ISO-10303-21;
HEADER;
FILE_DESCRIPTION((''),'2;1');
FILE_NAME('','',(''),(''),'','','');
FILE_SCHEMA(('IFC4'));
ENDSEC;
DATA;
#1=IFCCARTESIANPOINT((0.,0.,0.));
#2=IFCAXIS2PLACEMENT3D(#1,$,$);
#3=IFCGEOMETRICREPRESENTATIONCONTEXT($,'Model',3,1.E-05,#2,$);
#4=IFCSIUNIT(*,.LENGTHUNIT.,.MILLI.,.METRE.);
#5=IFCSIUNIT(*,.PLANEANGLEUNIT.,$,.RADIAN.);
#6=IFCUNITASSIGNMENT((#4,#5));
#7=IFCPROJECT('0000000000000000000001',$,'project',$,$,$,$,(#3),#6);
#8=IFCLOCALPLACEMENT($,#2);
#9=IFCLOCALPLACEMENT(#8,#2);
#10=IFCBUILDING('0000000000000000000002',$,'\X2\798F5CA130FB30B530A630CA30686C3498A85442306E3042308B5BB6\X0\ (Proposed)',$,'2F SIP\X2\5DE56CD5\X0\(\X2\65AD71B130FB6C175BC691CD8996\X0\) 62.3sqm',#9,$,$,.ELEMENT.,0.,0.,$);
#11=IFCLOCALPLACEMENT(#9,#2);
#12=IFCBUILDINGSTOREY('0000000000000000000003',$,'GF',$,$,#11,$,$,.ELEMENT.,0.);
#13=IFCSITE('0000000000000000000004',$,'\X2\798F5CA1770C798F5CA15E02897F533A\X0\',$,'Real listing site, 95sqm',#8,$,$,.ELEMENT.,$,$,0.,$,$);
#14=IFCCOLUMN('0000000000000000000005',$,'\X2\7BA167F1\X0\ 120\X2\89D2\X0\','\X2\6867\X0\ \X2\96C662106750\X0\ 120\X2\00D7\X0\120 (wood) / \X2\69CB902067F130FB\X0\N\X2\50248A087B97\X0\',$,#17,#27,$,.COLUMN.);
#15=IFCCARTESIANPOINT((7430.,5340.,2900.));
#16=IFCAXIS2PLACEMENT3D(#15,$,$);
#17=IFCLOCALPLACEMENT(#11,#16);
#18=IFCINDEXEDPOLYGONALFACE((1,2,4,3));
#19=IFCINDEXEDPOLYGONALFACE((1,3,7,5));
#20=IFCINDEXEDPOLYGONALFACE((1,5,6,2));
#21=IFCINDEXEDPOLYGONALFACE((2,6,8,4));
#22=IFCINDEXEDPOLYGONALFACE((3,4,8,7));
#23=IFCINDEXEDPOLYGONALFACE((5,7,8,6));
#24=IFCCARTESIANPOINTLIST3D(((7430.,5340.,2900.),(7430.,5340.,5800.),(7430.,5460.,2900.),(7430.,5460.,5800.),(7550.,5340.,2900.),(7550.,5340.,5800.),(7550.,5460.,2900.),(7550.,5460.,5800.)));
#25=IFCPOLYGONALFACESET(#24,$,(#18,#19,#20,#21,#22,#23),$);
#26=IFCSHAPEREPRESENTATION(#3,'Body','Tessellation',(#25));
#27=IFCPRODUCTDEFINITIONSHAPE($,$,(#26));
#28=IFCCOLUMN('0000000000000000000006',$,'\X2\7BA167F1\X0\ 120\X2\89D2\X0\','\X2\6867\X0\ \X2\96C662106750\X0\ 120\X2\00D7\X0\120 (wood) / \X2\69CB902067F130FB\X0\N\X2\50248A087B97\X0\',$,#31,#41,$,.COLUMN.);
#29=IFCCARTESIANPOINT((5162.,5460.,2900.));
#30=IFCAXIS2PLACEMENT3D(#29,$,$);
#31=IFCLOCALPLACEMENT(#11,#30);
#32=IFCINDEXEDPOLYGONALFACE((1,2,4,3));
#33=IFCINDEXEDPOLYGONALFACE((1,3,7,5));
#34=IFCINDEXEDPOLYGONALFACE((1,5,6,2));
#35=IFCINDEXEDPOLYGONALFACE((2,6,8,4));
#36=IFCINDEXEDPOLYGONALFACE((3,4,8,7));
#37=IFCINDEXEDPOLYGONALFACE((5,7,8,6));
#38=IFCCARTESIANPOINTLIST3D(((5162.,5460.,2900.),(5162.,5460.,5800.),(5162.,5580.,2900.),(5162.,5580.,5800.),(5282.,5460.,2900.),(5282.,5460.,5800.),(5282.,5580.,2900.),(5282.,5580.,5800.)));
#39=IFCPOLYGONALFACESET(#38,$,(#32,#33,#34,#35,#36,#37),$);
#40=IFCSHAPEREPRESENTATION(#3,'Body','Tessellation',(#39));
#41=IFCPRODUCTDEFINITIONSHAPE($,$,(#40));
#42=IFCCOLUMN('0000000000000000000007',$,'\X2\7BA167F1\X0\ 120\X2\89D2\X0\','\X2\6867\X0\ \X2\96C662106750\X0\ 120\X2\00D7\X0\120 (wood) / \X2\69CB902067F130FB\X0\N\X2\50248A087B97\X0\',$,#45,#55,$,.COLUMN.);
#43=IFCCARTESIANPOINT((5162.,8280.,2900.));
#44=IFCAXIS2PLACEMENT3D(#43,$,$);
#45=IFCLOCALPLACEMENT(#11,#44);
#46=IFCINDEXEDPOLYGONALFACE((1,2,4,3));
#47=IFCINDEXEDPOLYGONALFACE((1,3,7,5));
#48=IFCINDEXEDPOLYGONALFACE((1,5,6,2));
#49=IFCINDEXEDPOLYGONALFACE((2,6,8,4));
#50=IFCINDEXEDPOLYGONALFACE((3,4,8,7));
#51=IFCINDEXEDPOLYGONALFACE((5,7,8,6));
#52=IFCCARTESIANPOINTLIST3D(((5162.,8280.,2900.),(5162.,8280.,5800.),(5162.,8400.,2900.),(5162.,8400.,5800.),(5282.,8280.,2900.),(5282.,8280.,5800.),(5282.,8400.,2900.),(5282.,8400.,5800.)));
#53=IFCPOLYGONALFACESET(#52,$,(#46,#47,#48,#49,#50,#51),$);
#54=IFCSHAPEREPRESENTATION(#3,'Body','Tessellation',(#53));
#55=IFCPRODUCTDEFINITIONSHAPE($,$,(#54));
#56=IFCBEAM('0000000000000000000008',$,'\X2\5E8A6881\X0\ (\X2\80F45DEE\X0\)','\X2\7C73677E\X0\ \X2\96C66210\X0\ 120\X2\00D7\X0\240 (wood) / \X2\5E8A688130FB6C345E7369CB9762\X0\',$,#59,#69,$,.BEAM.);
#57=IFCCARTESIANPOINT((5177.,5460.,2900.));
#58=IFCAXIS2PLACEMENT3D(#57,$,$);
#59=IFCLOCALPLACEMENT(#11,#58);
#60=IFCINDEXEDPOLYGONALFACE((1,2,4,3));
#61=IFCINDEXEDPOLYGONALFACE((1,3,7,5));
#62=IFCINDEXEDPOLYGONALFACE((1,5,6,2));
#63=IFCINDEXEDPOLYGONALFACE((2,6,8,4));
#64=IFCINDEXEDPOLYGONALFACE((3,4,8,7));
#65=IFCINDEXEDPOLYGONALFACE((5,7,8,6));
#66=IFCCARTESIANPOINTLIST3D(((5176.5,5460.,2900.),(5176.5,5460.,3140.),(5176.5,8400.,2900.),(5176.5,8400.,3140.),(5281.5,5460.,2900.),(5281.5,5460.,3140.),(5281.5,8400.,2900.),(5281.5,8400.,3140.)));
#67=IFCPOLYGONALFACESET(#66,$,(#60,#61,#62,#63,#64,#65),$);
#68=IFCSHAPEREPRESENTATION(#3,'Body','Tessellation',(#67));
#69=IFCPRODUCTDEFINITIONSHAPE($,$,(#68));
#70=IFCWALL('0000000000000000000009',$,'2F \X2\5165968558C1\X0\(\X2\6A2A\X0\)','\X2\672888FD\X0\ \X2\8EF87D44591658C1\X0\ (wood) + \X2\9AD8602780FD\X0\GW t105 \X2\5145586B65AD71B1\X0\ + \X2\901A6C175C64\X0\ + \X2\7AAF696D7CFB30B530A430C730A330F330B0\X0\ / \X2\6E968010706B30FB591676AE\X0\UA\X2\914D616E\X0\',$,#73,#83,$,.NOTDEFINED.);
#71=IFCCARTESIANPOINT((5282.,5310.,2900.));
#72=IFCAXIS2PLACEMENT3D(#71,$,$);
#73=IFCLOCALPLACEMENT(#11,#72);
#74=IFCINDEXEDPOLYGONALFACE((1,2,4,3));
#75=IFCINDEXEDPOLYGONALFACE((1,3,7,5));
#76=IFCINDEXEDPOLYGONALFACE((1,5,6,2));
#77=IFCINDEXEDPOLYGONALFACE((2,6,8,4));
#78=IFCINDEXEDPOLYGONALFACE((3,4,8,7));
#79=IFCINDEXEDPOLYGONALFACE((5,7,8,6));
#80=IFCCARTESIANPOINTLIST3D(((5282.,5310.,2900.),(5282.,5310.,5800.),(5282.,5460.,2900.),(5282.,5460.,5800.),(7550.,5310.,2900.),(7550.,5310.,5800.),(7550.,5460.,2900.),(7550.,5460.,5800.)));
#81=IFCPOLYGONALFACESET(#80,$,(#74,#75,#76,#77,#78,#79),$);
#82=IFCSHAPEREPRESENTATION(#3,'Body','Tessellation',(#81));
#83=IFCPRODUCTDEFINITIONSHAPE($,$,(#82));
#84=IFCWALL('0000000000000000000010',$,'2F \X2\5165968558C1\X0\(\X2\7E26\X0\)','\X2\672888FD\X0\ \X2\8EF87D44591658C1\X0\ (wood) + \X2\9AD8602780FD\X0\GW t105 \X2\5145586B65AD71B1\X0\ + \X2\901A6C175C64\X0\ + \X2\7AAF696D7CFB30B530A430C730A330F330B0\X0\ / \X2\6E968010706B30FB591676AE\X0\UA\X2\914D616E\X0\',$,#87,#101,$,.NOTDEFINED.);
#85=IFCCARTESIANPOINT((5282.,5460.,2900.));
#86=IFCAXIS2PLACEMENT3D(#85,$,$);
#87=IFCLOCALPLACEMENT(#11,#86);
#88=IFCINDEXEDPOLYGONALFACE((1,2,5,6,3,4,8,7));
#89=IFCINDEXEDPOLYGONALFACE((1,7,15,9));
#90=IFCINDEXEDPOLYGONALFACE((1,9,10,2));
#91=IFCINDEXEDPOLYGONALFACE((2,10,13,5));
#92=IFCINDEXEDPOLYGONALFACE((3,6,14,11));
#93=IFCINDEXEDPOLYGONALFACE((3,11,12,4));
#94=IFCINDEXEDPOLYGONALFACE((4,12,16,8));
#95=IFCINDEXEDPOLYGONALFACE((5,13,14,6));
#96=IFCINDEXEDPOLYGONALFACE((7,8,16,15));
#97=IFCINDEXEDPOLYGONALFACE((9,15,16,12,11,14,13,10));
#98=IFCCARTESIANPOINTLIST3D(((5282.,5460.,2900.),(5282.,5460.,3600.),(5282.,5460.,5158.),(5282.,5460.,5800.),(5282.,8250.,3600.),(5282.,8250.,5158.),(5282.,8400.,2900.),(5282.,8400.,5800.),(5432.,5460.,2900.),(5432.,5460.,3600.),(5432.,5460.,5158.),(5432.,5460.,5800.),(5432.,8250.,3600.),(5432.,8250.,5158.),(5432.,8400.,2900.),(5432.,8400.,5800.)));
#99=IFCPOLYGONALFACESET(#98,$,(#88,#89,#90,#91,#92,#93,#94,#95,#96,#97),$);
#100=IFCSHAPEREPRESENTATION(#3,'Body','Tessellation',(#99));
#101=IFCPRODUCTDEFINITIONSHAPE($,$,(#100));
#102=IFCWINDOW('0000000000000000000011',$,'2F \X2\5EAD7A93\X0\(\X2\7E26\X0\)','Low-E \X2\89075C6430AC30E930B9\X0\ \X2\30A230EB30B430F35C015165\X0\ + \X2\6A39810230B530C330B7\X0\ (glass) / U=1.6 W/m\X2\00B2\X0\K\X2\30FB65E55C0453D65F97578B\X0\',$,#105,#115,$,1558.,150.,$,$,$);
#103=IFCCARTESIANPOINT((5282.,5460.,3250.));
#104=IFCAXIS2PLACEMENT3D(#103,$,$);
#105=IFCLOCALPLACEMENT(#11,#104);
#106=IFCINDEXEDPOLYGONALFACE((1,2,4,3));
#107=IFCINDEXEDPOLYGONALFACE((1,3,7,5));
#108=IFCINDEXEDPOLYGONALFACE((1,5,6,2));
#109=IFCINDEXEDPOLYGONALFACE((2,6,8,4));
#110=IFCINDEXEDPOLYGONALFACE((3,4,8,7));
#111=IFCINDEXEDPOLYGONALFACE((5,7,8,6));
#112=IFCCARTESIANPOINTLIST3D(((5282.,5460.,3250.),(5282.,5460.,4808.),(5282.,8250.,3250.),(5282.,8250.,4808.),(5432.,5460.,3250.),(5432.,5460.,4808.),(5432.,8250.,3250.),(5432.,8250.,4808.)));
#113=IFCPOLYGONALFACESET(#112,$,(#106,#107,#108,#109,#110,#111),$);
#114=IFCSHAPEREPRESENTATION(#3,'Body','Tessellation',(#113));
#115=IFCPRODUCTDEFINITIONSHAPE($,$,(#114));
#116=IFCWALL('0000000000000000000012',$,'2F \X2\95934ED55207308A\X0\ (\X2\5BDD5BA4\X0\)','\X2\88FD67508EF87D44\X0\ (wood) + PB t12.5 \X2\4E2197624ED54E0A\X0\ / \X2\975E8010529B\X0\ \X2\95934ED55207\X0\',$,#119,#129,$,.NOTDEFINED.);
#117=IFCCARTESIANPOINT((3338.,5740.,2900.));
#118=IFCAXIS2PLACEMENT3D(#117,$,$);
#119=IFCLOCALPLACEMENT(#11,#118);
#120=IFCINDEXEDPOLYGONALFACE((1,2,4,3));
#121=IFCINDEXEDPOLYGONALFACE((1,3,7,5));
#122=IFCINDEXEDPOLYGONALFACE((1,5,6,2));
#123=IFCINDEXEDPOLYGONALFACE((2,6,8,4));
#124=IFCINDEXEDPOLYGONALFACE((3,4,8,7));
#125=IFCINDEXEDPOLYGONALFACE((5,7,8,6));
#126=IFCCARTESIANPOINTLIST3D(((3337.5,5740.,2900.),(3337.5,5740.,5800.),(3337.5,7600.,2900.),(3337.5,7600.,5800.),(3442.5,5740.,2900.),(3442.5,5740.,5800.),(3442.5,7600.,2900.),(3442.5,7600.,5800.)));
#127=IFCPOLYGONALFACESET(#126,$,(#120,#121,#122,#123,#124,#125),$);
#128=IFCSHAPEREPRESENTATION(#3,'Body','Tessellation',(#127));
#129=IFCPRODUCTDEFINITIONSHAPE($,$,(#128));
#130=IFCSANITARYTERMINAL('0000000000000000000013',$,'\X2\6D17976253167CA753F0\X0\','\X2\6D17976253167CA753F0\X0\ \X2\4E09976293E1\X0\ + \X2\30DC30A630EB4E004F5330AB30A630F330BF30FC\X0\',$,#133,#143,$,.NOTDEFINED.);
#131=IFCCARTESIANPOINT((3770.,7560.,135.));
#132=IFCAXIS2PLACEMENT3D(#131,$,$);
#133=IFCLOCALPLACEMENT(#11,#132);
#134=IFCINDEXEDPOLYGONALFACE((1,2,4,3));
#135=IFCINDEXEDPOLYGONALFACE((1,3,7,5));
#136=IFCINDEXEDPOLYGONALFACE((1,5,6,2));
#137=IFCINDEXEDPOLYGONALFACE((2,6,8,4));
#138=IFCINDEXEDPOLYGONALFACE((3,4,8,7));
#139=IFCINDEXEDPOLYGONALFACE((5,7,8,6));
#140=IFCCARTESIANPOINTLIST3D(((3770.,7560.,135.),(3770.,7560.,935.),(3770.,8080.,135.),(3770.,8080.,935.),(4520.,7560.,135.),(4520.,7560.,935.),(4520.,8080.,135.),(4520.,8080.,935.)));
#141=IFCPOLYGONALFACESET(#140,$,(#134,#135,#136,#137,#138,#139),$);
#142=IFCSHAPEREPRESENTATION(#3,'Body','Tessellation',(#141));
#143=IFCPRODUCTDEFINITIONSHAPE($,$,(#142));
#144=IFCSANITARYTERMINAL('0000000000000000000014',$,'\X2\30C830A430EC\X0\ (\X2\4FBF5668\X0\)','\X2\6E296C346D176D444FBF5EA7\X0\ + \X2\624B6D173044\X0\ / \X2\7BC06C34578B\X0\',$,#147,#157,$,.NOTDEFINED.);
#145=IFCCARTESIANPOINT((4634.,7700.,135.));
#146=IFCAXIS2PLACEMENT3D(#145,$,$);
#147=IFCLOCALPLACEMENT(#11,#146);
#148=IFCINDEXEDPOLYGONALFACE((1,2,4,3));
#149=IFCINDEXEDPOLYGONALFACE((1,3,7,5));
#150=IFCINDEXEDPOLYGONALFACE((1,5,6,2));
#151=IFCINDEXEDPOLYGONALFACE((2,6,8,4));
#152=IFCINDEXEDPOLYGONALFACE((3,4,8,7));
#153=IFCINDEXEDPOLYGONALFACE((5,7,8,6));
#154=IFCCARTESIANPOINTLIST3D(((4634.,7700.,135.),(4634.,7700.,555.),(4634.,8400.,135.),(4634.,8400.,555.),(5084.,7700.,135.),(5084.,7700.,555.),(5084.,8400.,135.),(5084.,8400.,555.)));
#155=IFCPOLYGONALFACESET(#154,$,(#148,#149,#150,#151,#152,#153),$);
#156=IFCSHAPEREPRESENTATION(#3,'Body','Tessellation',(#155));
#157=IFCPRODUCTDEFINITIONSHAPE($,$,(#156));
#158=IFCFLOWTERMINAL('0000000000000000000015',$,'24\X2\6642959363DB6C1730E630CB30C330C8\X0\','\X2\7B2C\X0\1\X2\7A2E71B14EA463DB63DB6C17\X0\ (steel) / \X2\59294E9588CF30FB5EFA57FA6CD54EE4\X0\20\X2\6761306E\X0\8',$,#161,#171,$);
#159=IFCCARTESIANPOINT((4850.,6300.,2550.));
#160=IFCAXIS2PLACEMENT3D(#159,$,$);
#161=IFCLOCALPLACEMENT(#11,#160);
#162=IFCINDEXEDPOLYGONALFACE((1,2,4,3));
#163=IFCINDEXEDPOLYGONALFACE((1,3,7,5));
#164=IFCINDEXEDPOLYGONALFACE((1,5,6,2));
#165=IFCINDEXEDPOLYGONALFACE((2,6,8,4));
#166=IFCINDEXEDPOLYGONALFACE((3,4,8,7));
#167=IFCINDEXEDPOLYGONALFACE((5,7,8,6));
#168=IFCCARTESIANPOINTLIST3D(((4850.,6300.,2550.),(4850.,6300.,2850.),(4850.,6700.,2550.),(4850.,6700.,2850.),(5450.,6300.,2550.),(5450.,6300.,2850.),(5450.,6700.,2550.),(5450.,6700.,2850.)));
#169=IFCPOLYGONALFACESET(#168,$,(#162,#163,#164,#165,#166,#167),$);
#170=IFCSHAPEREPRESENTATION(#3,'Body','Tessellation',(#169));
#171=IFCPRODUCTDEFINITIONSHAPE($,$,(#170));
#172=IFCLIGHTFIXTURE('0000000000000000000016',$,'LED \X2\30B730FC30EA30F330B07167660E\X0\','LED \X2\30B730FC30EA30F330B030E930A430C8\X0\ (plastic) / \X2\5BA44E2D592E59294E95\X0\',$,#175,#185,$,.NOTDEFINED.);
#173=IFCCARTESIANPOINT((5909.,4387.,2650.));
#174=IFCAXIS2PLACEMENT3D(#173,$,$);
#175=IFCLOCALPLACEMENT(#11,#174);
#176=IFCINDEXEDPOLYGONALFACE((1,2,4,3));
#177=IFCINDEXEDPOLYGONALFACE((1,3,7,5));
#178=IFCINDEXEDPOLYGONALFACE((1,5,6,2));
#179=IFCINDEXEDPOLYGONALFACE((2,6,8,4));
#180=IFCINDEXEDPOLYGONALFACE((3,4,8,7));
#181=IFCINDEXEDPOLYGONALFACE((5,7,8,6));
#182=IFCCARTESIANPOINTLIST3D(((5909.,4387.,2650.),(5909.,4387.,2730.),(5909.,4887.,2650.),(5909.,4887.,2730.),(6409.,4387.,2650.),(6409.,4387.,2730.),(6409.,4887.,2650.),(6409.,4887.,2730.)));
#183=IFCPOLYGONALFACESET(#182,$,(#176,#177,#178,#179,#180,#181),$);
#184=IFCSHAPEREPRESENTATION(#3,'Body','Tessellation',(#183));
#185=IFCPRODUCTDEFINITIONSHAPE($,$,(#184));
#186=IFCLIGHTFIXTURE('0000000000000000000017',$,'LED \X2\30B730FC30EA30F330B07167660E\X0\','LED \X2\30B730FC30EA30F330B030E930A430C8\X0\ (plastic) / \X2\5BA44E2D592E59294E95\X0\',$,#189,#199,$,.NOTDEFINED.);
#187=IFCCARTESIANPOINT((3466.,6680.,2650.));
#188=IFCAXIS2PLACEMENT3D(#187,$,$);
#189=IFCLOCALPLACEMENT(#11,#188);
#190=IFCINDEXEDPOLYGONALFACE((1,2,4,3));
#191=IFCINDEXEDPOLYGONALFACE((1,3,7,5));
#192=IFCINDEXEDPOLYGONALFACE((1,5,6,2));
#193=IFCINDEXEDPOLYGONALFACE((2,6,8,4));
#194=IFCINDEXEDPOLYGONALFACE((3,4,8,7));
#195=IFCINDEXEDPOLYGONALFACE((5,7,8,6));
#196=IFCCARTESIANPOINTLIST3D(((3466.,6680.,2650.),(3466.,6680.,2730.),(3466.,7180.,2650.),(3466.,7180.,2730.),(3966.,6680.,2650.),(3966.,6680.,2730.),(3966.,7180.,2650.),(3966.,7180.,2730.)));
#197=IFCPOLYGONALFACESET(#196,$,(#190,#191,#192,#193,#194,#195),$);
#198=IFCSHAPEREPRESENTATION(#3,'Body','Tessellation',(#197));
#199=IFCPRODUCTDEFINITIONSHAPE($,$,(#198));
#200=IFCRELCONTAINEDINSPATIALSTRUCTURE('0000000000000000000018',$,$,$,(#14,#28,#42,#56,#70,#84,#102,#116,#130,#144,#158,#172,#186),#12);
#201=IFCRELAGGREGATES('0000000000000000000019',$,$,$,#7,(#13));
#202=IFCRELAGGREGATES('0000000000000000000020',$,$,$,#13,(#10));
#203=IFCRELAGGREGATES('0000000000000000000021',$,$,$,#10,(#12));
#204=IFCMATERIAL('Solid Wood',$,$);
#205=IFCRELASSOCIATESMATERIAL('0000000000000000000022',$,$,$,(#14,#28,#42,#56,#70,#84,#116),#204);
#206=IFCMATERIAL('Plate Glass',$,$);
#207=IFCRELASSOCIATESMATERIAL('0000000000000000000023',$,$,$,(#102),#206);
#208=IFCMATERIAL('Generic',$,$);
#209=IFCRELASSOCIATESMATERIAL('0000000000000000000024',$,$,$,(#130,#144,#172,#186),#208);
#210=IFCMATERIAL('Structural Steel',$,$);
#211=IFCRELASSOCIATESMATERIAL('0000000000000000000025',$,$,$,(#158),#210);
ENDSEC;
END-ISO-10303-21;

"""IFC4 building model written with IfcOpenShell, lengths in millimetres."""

from ifc_helpers import new_model, si_unit, frame, frame_2d, origin, place, context, project, spatial, rectangle, extrude, material, element, fill, save


model = new_model("IFC4")

# Units and contexts
model_context = context("Model", 3, precision=1e-05, world=origin())
ifc_project = project(units=[si_unit("LENGTHUNIT", "METRE", prefix="MILLI"), si_unit("PLANEANGLEUNIT", "RADIAN")], contexts=[model_context])

# Site, building, storey
site_placement = place(None, origin())
site = spatial("IfcSite", under=ifc_project, at=site_placement, Name="福岡県福岡市西区", ObjectType="Real listing site, 95sqm", CompositionType="ELEMENT", RefElevation=0.0)
building_placement = place(site_placement, origin())
building = spatial("IfcBuilding", under=site, at=building_placement, Name="福岡・サウナと水風呂のある家 (Proposed)", ObjectType="2F SIP工法(断熱・気密重視) 62.3sqm", CompositionType="ELEMENT", ElevationOfRefHeight=0.0, ElevationOfTerrain=0.0)
storey_placement = place(building_placement, origin())
storey = spatial("IfcBuildingStorey", under=building, at=storey_placement, Name="GF", CompositionType="ELEMENT", Elevation=0.0)

# Columns
ifc_material_1 = material(Name="Solid Wood")
column_1_placement = place(storey_placement, frame((7430.0, 5340.0, 2900.0)))
element("IfcColumn", 1, at=column_1_placement, inside=storey, material=ifc_material_1, Name="管柱 120角", Description="桧 集成材 120×120 (wood) / 構造柱・N値計算", PredefinedType="COLUMN", context=model_context, shape_type="SweptSolid", body=[
    extrude(rectangle(XDim=120.0, YDim=120.0, at=frame_2d((60.0, 60.0))), frame((7430.0, 5340.0, 2900.0)), (0.0, 0.0, 1.0), 2900.0),
])
column_2_placement = place(storey_placement, frame((5162.0, 5460.0, 2900.0)))
element("IfcColumn", 2, at=column_2_placement, inside=storey, material=ifc_material_1, Name="管柱 120角", Description="桧 集成材 120×120 (wood) / 構造柱・N値計算", PredefinedType="COLUMN", context=model_context, shape_type="SweptSolid", body=[
    extrude(rectangle(XDim=120.0, YDim=120.0, at=frame_2d((60.0, 60.0))), frame((5162.0, 5460.0, 2900.0)), (0.0, 0.0, 1.0), 2900.0),
])
column_3_placement = place(storey_placement, frame((5162.0, 8280.0, 2900.0)))
element("IfcColumn", 3, at=column_3_placement, inside=storey, material=ifc_material_1, Name="管柱 120角", Description="桧 集成材 120×120 (wood) / 構造柱・N値計算", PredefinedType="COLUMN", context=model_context, shape_type="SweptSolid", body=[
    extrude(rectangle(XDim=120.0, YDim=120.0, at=frame_2d((60.0, 60.0))), frame((5162.0, 8280.0, 2900.0)), (0.0, 0.0, 1.0), 2900.0),
])

# Beam
beam_placement = place(storey_placement, frame((5177.0, 5460.0, 2900.0)))
element("IfcBeam", 4, at=beam_placement, inside=storey, material=ifc_material_1, Name="床梁 (胴差)", Description="米松 集成 120×240 (wood) / 床梁・水平構面", PredefinedType="BEAM", context=model_context, shape_type="SweptSolid", body=[
    extrude(rectangle(XDim=105.0, YDim=2940.0, at=frame_2d((52.0, 1470.0))), frame((5177.0, 5460.0, 2900.0)), (0.0, 0.0, 1.0), 240.0),
])

# Wall
wall_1_placement = place(storey_placement, frame((5282.0, 5310.0, 2900.0)))
element("IfcWall", 5, at=wall_1_placement, inside=storey, material=ifc_material_1, Name="2F 入隅壁(横)", Description="木製 軸組外壁 (wood) + 高性能GW t105 充填断熱 + 通気層 + 窯業系サイディング / 準耐火・外皮UA配慮", PredefinedType="NOTDEFINED", context=model_context, shape_type="SweptSolid", body=[
    extrude(rectangle(XDim=2268.0, YDim=150.0, at=frame_2d((1134.0, 75.0))), frame((5282.0, 5310.0, 2900.0)), (0.0, 0.0, 1.0), 2900.0),
])

# Wall, opening, window
wall_2_placement = place(storey_placement, frame((5282.0, 5460.0, 2900.0)))
wall_2 = element("IfcWall", 6, at=wall_2_placement, inside=storey, material=ifc_material_1, Name="2F 入隅壁(縦)", Description="木製 軸組外壁 (wood) + 高性能GW t105 充填断熱 + 通気層 + 窯業系サイディング / 準耐火・外皮UA配慮", PredefinedType="NOTDEFINED", context=model_context, shape_type="SweptSolid", body=[
    extrude(rectangle(XDim=150.0, YDim=2940.0, at=frame_2d((75.0, 1470.0))), frame((5282.0, 5460.0, 2900.0)), (0.0, 0.0, 1.0), 2900.0),
])
opening_placement = place(storey_placement, frame((5282.0, 5460.0, 3250.0)))
opening = element("IfcOpeningElement", 7, at=opening_placement, cuts=wall_2, PredefinedType="NOTDEFINED", context=model_context, shape_type="SweptSolid", body=[
    extrude(rectangle(XDim=150.0, YDim=2790.0, at=frame_2d((75.0, 1395.0))), frame((5282.0, 5460.0, 3250.0)), (0.0, 0.0, 1.0), 1558.0),
])
ifc_material_2 = material(Name="Plate Glass")
window_placement = place(storey_placement, frame((5282.0, 5460.0, 3250.0)))
window = element("IfcWindow", 8, at=window_placement, inside=storey, material=ifc_material_2, Name="2F 庭窓(縦)", Description="Low-E 複層ガラス アルゴン封入 + 樹脂サッシ (glass) / U=1.6 W/m²K・日射取得型", OverallHeight=1558.0, OverallWidth=150.0, context=model_context, shape_type="SweptSolid", body=[
    extrude(rectangle(XDim=150.0, YDim=2790.0, at=frame_2d((75.0, 1395.0))), frame((5282.0, 5460.0, 3250.0)), (0.0, 0.0, 1.0), 1558.0),
])
fill(opening, window)

# Wall
wall_3_placement = place(storey_placement, frame((3338.0, 5740.0, 2900.0)))
element("IfcWall", 9, at=wall_3_placement, inside=storey, material=ifc_material_1, Name="2F 間仕切り (寝室)", Description="製材軸組 (wood) + PB t12.5 両面仕上 / 非耐力 間仕切", PredefinedType="NOTDEFINED", context=model_context, shape_type="SweptSolid", body=[
    extrude(rectangle(XDim=105.0, YDim=1860.0, at=frame_2d((52.0, 930.0))), frame((3338.0, 5740.0, 2900.0)), (0.0, 0.0, 1.0), 2900.0),
])

# Sanitary terminals
ifc_material_3 = material(Name="Generic")
sanitary_terminal_1_placement = place(storey_placement, frame((3770.0, 7560.0, 135.0)))
element("IfcSanitaryTerminal", 10, at=sanitary_terminal_1_placement, inside=storey, material=ifc_material_3, Name="洗面化粧台", Description="洗面化粧台 三面鏡 + ボウル一体カウンター", PredefinedType="NOTDEFINED", context=model_context, shape_type="SweptSolid", body=[
    extrude(rectangle(XDim=750.0, YDim=520.0, at=frame_2d((375.0, 260.0))), frame((3770.0, 7560.0, 135.0)), (0.0, 0.0, 1.0), 800.0),
])
sanitary_terminal_2_placement = place(storey_placement, frame((4634.0, 7700.0, 135.0)))
element("IfcSanitaryTerminal", 11, at=sanitary_terminal_2_placement, inside=storey, material=ifc_material_3, Name="トイレ (便器)", Description="温水洗浄便座 + 手洗い / 節水型", PredefinedType="NOTDEFINED", context=model_context, shape_type="SweptSolid", body=[
    extrude(rectangle(XDim=450.0, YDim=700.0, at=frame_2d((225.0, 350.0))), frame((4634.0, 7700.0, 135.0)), (0.0, 0.0, 1.0), 420.0),
])

# Flow terminal
ifc_material_4 = material(Name="Structural Steel")
flow_terminal_placement = place(storey_placement, frame((4850.0, 6300.0, 2550.0)))
element("IfcFlowTerminal", 12, at=flow_terminal_placement, inside=storey, material=ifc_material_4, Name="24時間換気ユニット", Description="第1種熱交換換気 (steel) / 天井裏・建基法令20条の8", context=model_context, shape_type="SweptSolid", body=[
    extrude(rectangle(XDim=600.0, YDim=400.0, at=frame_2d((300.0, 200.0))), frame((4850.0, 6300.0, 2550.0)), (0.0, 0.0, 1.0), 300.0),
])

# Light fixtures
light_fixture_1_placement = place(storey_placement, frame((5909.0, 4387.0, 2650.0)))
element("IfcLightFixture", 13, at=light_fixture_1_placement, inside=storey, material=ifc_material_3, Name="LED シーリング照明", Description="LED シーリングライト (plastic) / 室中央天井", PredefinedType="NOTDEFINED", context=model_context, shape_type="SweptSolid", body=[
    extrude(rectangle(XDim=500.0, YDim=500.0, at=frame_2d((250.0, 250.0))), frame((5909.0, 4387.0, 2650.0)), (0.0, 0.0, 1.0), 80.0),
])
light_fixture_2_placement = place(storey_placement, frame((3466.0, 6680.0, 2650.0)))
element("IfcLightFixture", 14, at=light_fixture_2_placement, inside=storey, material=ifc_material_3, Name="LED シーリング照明", Description="LED シーリングライト (plastic) / 室中央天井", PredefinedType="NOTDEFINED", context=model_context, shape_type="SweptSolid", body=[
    extrude(rectangle(XDim=500.0, YDim=500.0, at=frame_2d((250.0, 250.0))), frame((3466.0, 6680.0, 2650.0)), (0.0, 0.0, 1.0), 80.0),
])

save(model, "model.ifc")
